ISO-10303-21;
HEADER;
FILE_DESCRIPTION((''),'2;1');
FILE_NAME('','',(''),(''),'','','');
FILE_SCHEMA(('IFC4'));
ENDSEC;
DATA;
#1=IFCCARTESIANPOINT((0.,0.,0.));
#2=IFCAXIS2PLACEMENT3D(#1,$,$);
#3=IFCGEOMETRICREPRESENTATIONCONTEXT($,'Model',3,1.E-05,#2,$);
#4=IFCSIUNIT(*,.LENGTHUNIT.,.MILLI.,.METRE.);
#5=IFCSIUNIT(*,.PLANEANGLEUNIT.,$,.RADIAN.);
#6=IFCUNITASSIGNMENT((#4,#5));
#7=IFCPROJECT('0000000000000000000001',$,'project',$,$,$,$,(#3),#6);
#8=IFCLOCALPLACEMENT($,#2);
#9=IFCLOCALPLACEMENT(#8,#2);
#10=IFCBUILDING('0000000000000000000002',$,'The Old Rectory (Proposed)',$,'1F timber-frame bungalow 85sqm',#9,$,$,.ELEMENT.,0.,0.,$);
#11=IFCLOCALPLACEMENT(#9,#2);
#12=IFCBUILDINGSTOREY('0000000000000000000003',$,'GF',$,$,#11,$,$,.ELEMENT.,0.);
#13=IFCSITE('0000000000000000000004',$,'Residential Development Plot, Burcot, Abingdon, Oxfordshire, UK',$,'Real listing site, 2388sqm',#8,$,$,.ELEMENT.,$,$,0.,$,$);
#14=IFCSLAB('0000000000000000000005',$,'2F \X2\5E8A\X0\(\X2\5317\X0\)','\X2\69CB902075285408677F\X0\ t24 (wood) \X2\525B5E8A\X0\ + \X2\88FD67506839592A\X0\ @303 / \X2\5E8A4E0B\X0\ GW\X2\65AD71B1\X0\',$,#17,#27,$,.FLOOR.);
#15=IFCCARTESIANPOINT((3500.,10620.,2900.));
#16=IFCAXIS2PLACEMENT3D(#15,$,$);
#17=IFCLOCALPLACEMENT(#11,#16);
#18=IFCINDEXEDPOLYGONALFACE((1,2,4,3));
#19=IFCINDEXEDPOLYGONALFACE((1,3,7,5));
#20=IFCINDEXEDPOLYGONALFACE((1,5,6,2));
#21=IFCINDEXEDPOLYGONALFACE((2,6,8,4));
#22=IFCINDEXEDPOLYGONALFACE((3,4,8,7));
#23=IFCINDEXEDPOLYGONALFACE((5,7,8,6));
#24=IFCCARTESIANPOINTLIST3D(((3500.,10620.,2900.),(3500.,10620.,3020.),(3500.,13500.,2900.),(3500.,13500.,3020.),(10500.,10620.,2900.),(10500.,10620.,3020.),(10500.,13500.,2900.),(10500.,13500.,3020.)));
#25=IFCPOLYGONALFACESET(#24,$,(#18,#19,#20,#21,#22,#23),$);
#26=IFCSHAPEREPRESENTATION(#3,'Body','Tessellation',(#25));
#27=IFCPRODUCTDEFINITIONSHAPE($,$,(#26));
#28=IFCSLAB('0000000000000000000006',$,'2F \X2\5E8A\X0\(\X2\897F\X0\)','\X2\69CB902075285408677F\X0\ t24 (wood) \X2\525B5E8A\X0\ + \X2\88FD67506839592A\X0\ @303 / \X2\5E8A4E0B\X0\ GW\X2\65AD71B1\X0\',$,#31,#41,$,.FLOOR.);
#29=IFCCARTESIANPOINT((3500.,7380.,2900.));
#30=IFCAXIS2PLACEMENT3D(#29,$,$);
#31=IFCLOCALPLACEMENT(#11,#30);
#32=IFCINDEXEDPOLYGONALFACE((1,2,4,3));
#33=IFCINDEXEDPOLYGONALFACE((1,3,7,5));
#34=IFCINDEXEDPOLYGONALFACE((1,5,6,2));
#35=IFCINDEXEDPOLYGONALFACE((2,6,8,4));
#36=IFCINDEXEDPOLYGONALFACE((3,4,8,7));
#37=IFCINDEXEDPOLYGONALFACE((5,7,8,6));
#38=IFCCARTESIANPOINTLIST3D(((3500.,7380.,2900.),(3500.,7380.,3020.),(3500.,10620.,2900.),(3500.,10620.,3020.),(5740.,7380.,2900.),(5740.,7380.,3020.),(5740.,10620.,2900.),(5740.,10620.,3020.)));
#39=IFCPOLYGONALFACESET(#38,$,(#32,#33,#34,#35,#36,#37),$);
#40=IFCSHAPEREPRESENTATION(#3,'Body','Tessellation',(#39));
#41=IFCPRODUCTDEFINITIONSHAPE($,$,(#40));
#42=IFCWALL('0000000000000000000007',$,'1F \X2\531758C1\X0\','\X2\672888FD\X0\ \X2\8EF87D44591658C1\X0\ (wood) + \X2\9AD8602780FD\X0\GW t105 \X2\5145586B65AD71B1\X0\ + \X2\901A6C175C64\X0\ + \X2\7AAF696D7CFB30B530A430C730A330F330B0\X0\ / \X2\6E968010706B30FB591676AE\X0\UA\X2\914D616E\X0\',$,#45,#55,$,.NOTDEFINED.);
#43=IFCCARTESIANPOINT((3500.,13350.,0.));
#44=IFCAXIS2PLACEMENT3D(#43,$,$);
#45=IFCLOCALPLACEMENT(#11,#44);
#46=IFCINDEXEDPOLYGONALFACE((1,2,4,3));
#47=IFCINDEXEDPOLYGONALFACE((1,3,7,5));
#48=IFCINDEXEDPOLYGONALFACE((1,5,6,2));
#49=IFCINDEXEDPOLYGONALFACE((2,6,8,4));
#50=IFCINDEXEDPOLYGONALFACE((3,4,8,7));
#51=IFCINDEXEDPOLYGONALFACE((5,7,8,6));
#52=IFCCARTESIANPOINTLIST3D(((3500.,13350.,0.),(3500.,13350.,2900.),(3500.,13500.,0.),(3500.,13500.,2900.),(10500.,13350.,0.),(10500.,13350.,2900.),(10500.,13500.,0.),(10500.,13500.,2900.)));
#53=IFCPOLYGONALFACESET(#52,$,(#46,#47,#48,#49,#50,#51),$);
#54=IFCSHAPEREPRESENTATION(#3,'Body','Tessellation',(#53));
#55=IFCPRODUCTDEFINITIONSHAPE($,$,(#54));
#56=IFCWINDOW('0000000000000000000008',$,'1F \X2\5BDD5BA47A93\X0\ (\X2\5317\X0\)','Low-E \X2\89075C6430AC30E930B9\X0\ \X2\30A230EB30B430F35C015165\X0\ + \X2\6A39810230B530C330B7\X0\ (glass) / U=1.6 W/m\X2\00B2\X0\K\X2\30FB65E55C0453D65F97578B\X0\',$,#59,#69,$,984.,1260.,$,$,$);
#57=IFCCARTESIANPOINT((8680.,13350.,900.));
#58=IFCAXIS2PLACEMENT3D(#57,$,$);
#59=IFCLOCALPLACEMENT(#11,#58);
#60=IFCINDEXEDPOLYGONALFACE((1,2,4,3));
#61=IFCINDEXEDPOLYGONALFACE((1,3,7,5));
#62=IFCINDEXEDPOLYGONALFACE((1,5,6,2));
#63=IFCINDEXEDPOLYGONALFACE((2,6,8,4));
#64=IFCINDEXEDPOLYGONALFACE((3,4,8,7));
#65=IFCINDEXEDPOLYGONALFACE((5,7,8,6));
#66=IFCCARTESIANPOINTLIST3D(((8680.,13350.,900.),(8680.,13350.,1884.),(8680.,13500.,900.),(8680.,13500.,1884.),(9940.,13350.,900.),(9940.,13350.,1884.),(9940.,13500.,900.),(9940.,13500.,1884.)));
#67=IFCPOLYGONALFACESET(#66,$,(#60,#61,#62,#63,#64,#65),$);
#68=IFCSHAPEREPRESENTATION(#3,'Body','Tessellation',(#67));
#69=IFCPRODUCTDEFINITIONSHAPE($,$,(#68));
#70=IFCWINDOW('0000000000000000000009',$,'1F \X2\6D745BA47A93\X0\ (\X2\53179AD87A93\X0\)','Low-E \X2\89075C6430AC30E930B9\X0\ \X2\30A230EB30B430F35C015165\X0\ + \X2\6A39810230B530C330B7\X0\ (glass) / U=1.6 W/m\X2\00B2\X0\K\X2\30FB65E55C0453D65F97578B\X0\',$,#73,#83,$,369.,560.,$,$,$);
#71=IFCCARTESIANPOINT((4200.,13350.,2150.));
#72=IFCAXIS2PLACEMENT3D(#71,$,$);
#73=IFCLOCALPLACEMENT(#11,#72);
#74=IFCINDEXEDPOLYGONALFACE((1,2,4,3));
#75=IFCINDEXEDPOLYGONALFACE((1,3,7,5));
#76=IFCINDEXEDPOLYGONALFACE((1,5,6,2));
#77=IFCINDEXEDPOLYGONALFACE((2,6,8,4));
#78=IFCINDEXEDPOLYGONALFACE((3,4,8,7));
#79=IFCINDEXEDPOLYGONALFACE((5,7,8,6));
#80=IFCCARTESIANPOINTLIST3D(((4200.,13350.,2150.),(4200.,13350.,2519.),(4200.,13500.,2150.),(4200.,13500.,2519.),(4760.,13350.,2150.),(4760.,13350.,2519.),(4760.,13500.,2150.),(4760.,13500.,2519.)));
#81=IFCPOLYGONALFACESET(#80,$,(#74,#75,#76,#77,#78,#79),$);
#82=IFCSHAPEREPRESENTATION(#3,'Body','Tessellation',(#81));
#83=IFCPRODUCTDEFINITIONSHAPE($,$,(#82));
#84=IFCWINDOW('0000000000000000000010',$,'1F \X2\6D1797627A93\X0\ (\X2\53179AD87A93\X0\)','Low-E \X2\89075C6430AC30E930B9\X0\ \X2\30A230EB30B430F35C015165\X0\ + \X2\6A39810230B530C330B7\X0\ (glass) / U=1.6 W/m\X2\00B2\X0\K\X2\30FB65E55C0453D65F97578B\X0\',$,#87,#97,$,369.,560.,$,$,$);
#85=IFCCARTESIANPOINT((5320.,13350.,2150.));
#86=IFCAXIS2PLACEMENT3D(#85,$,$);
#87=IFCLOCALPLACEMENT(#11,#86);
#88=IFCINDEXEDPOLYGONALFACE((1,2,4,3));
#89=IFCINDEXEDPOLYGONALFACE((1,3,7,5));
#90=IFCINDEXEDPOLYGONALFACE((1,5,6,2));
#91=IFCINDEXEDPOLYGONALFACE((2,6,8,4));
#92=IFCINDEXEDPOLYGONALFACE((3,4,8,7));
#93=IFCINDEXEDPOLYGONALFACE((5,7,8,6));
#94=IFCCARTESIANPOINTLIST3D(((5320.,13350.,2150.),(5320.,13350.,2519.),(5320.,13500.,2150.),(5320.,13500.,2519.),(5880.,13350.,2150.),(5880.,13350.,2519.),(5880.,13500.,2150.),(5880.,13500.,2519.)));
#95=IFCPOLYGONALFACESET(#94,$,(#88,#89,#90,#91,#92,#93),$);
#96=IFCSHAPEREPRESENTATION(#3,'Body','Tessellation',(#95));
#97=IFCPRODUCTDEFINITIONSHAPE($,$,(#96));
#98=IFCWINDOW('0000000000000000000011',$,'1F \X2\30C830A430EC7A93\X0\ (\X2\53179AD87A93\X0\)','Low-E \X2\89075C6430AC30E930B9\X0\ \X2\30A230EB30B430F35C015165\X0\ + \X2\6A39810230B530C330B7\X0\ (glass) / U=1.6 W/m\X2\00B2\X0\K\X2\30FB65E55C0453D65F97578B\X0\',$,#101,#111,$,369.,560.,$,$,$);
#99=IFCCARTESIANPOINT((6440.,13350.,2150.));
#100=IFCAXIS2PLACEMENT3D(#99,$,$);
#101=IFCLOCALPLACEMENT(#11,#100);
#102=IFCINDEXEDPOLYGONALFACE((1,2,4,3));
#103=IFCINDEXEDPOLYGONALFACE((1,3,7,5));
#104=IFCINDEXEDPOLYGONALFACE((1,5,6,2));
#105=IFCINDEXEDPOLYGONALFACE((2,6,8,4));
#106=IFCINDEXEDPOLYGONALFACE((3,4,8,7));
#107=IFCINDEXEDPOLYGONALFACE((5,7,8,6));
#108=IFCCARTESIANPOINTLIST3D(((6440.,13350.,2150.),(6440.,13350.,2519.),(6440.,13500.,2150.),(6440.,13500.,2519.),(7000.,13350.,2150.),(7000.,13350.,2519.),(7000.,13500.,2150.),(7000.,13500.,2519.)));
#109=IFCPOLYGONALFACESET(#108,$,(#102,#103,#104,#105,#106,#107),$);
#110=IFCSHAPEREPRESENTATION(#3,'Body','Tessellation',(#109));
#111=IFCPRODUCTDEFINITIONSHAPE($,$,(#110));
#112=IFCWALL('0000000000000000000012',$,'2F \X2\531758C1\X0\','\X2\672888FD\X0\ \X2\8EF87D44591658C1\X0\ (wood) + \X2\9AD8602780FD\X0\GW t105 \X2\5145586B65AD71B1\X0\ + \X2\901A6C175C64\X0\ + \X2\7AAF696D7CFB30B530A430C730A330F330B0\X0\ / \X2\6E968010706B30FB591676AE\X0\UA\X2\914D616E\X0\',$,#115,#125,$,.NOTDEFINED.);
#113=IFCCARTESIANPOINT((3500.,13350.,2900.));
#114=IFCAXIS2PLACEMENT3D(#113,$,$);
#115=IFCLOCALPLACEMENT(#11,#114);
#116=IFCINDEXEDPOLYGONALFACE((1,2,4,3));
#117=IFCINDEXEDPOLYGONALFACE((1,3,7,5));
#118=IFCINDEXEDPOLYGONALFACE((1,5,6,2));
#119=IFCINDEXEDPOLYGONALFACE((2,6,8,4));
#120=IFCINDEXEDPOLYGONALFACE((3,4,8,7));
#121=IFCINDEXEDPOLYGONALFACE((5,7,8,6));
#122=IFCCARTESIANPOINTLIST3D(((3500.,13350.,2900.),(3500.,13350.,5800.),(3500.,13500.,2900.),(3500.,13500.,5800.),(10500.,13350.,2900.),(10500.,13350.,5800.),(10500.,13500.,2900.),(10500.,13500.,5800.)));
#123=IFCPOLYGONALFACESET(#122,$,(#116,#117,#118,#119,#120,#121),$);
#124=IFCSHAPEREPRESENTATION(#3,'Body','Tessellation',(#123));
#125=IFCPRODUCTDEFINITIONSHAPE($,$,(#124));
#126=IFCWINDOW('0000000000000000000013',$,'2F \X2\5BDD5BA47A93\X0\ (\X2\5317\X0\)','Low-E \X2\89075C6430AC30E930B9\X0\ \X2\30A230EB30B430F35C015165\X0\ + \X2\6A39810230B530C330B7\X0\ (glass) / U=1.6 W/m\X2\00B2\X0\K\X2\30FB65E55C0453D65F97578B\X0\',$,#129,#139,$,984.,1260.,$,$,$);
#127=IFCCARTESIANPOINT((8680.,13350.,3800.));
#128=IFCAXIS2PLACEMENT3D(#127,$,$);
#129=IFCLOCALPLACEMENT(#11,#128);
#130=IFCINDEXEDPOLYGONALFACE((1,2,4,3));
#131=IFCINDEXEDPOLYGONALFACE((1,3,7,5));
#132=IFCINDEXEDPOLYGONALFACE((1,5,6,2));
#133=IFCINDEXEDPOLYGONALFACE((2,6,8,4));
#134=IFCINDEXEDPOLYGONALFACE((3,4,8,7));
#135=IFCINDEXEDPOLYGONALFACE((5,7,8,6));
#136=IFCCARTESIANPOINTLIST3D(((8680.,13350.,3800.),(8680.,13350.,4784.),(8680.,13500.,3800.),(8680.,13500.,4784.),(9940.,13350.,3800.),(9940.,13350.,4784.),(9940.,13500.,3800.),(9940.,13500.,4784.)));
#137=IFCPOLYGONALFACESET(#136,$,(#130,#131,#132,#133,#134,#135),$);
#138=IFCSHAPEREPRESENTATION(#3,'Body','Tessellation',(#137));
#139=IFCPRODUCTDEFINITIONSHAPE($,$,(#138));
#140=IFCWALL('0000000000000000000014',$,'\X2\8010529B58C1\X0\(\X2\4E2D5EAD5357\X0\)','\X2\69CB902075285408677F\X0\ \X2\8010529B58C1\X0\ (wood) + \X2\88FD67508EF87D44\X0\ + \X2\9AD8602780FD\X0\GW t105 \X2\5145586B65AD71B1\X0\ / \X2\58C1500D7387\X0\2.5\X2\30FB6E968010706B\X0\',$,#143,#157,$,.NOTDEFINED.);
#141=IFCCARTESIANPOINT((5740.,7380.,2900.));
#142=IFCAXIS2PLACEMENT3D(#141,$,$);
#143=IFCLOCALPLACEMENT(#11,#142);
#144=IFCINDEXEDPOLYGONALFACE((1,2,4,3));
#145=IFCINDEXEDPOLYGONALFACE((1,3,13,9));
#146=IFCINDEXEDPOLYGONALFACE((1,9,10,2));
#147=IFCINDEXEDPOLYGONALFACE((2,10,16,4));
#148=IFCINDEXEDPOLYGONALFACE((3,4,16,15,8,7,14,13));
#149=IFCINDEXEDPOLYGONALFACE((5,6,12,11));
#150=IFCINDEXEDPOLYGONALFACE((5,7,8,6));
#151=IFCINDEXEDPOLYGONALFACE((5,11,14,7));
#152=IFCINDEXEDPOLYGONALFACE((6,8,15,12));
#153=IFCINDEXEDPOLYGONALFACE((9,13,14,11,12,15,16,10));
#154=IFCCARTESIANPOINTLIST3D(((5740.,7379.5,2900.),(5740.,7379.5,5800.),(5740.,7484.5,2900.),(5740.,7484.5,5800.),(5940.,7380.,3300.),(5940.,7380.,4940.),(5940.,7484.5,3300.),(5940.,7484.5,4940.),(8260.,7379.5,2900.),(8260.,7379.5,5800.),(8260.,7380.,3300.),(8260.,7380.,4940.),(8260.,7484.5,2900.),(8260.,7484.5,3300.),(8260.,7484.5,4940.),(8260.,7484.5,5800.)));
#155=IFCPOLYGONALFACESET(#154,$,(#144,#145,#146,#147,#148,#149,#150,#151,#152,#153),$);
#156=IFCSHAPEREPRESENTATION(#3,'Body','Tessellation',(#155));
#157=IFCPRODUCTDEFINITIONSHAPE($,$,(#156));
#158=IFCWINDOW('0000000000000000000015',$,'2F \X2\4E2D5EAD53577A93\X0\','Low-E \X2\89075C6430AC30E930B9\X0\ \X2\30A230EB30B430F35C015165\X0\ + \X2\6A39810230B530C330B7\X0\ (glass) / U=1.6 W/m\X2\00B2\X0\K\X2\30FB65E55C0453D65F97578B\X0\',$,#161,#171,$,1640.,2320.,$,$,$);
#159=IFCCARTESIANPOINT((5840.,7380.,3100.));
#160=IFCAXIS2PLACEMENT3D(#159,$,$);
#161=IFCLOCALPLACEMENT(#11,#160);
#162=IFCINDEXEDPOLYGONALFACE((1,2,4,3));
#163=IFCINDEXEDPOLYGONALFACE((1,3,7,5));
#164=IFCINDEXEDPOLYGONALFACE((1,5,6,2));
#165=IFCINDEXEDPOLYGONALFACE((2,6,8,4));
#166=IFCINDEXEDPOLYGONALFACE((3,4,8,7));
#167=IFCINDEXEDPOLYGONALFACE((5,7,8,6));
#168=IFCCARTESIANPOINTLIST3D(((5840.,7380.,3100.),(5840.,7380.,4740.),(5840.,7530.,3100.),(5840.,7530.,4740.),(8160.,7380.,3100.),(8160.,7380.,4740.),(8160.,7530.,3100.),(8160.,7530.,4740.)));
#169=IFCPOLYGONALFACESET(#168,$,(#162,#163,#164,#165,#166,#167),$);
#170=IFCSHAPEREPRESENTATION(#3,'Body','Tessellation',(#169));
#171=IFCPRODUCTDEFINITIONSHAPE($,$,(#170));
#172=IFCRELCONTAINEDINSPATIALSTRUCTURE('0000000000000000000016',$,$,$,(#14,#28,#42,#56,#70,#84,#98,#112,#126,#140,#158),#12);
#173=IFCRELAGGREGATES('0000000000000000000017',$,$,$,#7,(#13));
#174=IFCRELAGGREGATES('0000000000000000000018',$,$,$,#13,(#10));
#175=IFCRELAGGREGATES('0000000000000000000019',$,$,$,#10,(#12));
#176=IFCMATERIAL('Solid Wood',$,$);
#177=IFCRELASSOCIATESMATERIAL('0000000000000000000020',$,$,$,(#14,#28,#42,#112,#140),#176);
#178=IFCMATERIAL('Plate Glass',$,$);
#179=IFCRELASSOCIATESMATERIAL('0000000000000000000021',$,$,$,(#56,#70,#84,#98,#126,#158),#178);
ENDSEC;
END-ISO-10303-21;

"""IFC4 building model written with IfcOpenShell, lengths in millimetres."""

from ifc_helpers import new_model, si_unit, frame, frame_2d, origin, place, context, project, spatial, rectangle, extrude, material, element, fill, save


model = new_model("IFC4")

# Units and contexts
model_context = context("Model", 3, precision=1e-05, world=origin())
ifc_project = project(units=[si_unit("LENGTHUNIT", "METRE", prefix="MILLI"), si_unit("PLANEANGLEUNIT", "RADIAN")], contexts=[model_context])

# Site, building, storey
site_placement = place(None, origin())
site = spatial("IfcSite", under=ifc_project, at=site_placement, Name="Residential Development Plot, Burcot, Abingdon, Oxfordshire, UK", ObjectType="Real listing site, 2388sqm", CompositionType="ELEMENT", RefElevation=0.0)
building_placement = place(site_placement, origin())
building = spatial("IfcBuilding", under=site, at=building_placement, Name="The Old Rectory (Proposed)", ObjectType="1F timber-frame bungalow 85sqm", CompositionType="ELEMENT", ElevationOfRefHeight=0.0, ElevationOfTerrain=0.0)
storey_placement = place(building_placement, origin())
storey = spatial("IfcBuildingStorey", under=building, at=storey_placement, Name="GF", CompositionType="ELEMENT", Elevation=0.0)

# Slabs
ifc_material_1 = material(Name="Solid Wood")
slab_1_placement = place(storey_placement, frame((3500.0, 10620.0, 2900.0)))
element("IfcSlab", 1, at=slab_1_placement, inside=storey, material=ifc_material_1, Name="2F 床(北)", Description="構造用合板 t24 (wood) 剛床 + 製材根太 @303 / 床下 GW断熱", PredefinedType="FLOOR", context=model_context, shape_type="SweptSolid", body=[
    extrude(rectangle(XDim=7000.0, YDim=2880.0, at=frame_2d((3500.0, 1440.0))), frame((3500.0, 10620.0, 2900.0)), (0.0, 0.0, 1.0), 120.0),
])
slab_2_placement = place(storey_placement, frame((3500.0, 7380.0, 2900.0)))
element("IfcSlab", 2, at=slab_2_placement, inside=storey, material=ifc_material_1, Name="2F 床(西)", Description="構造用合板 t24 (wood) 剛床 + 製材根太 @303 / 床下 GW断熱", PredefinedType="FLOOR", context=model_context, shape_type="SweptSolid", body=[
    extrude(rectangle(XDim=2240.0, YDim=3240.0, at=frame_2d((1120.0, 1620.0))), frame((3500.0, 7380.0, 2900.0)), (0.0, 0.0, 1.0), 120.0),
])

# Wall, openings, windows
wall_1_placement = place(storey_placement, frame((3500.0, 13350.0, 0.0)))
wall_1 = element("IfcWall", 3, at=wall_1_placement, inside=storey, material=ifc_material_1, Name="1F 北壁", Description="木製 軸組外壁 (wood) + 高性能GW t105 充填断熱 + 通気層 + 窯業系サイディング / 準耐火・外皮UA配慮", PredefinedType="NOTDEFINED", context=model_context, shape_type="SweptSolid", body=[
    extrude(rectangle(XDim=7000.0, YDim=150.0, at=frame_2d((3500.0, 75.0))), frame((3500.0, 13350.0, 0.0)), (0.0, 0.0, 1.0), 2900.0),
])
opening_1_placement = place(storey_placement, frame((8680.0, 13350.0, 900.0)))
opening_1 = element("IfcOpeningElement", 4, at=opening_1_placement, cuts=wall_1, PredefinedType="NOTDEFINED", context=model_context, shape_type="SweptSolid", body=[
    extrude(rectangle(XDim=1260.0, YDim=150.0, at=frame_2d((630.0, 75.0))), frame((8680.0, 13350.0, 900.0)), (0.0, 0.0, 1.0), 984.0),
])
opening_2_placement = place(storey_placement, frame((4200.0, 13350.0, 2150.0)))
opening_2 = element("IfcOpeningElement", 5, at=opening_2_placement, cuts=wall_1, PredefinedType="NOTDEFINED", context=model_context, shape_type="SweptSolid", body=[
    extrude(rectangle(XDim=560.0, YDim=150.0, at=frame_2d((280.0, 75.0))), frame((4200.0, 13350.0, 2150.0)), (0.0, 0.0, 1.0), 369.0),
])
opening_3_placement = place(storey_placement, frame((5320.0, 13350.0, 2150.0)))
opening_3 = element("IfcOpeningElement", 6, at=opening_3_placement, cuts=wall_1, PredefinedType="NOTDEFINED", context=model_context, shape_type="SweptSolid", body=[
    extrude(rectangle(XDim=560.0, YDim=150.0, at=frame_2d((280.0, 75.0))), frame((5320.0, 13350.0, 2150.0)), (0.0, 0.0, 1.0), 369.0),
])
opening_4_placement = place(storey_placement, frame((6440.0, 13350.0, 2150.0)))
opening_4 = element("IfcOpeningElement", 7, at=opening_4_placement, cuts=wall_1, PredefinedType="NOTDEFINED", context=model_context, shape_type="SweptSolid", body=[
    extrude(rectangle(XDim=560.0, YDim=150.0, at=frame_2d((280.0, 75.0))), frame((6440.0, 13350.0, 2150.0)), (0.0, 0.0, 1.0), 369.0),
])
ifc_material_2 = material(Name="Plate Glass")
window_1_placement = place(storey_placement, frame((8680.0, 13350.0, 900.0)))
window_1 = element("IfcWindow", 8, at=window_1_placement, inside=storey, material=ifc_material_2, Name="1F 寝室窓 (北)", Description="Low-E 複層ガラス アルゴン封入 + 樹脂サッシ (glass) / U=1.6 W/m²K・日射取得型", OverallHeight=984.0, OverallWidth=1260.0, context=model_context, shape_type="SweptSolid", body=[
    extrude(rectangle(XDim=1260.0, YDim=150.0, at=frame_2d((630.0, 75.0))), frame((8680.0, 13350.0, 900.0)), (0.0, 0.0, 1.0), 984.0),
])
fill(opening_1, window_1)
window_2_placement = place(storey_placement, frame((4200.0, 13350.0, 2150.0)))
window_2 = element("IfcWindow", 9, at=window_2_placement, inside=storey, material=ifc_material_2, Name="1F 浴室窓 (北高窓)", Description="Low-E 複層ガラス アルゴン封入 + 樹脂サッシ (glass) / U=1.6 W/m²K・日射取得型", OverallHeight=369.0, OverallWidth=560.0, context=model_context, shape_type="SweptSolid", body=[
    extrude(rectangle(XDim=560.0, YDim=150.0, at=frame_2d((280.0, 75.0))), frame((4200.0, 13350.0, 2150.0)), (0.0, 0.0, 1.0), 369.0),
])
fill(opening_2, window_2)
window_3_placement = place(storey_placement, frame((5320.0, 13350.0, 2150.0)))
window_3 = element("IfcWindow", 10, at=window_3_placement, inside=storey, material=ifc_material_2, Name="1F 洗面窓 (北高窓)", Description="Low-E 複層ガラス アルゴン封入 + 樹脂サッシ (glass) / U=1.6 W/m²K・日射取得型", OverallHeight=369.0, OverallWidth=560.0, context=model_context, shape_type="SweptSolid", body=[
    extrude(rectangle(XDim=560.0, YDim=150.0, at=frame_2d((280.0, 75.0))), frame((5320.0, 13350.0, 2150.0)), (0.0, 0.0, 1.0), 369.0),
])
fill(opening_3, window_3)
window_4_placement = place(storey_placement, frame((6440.0, 13350.0, 2150.0)))
window_4 = element("IfcWindow", 11, at=window_4_placement, inside=storey, material=ifc_material_2, Name="1F トイレ窓 (北高窓)", Description="Low-E 複層ガラス アルゴン封入 + 樹脂サッシ (glass) / U=1.6 W/m²K・日射取得型", OverallHeight=369.0, OverallWidth=560.0, context=model_context, shape_type="SweptSolid", body=[
    extrude(rectangle(XDim=560.0, YDim=150.0, at=frame_2d((280.0, 75.0))), frame((6440.0, 13350.0, 2150.0)), (0.0, 0.0, 1.0), 369.0),
])
fill(opening_4, window_4)

# Walls, openings, windows
wall_2_placement = place(storey_placement, frame((3500.0, 13350.0, 2900.0)))
wall_2 = element("IfcWall", 12, at=wall_2_placement, inside=storey, material=ifc_material_1, Name="2F 北壁", Description="木製 軸組外壁 (wood) + 高性能GW t105 充填断熱 + 通気層 + 窯業系サイディング / 準耐火・外皮UA配慮", PredefinedType="NOTDEFINED", context=model_context, shape_type="SweptSolid", body=[
    extrude(rectangle(XDim=7000.0, YDim=150.0, at=frame_2d((3500.0, 75.0))), frame((3500.0, 13350.0, 2900.0)), (0.0, 0.0, 1.0), 2900.0),
])
opening_5_placement = place(storey_placement, frame((8680.0, 13350.0, 3800.0)))
opening_5 = element("IfcOpeningElement", 13, at=opening_5_placement, cuts=wall_2, PredefinedType="NOTDEFINED", context=model_context, shape_type="SweptSolid", body=[
    extrude(rectangle(XDim=1260.0, YDim=150.0, at=frame_2d((630.0, 75.0))), frame((8680.0, 13350.0, 3800.0)), (0.0, 0.0, 1.0), 984.0),
])
window_5_placement = place(storey_placement, frame((8680.0, 13350.0, 3800.0)))
window_5 = element("IfcWindow", 14, at=window_5_placement, inside=storey, material=ifc_material_2, Name="2F 寝室窓 (北)", Description="Low-E 複層ガラス アルゴン封入 + 樹脂サッシ (glass) / U=1.6 W/m²K・日射取得型", OverallHeight=984.0, OverallWidth=1260.0, context=model_context, shape_type="SweptSolid", body=[
    extrude(rectangle(XDim=1260.0, YDim=150.0, at=frame_2d((630.0, 75.0))), frame((8680.0, 13350.0, 3800.0)), (0.0, 0.0, 1.0), 984.0),
])
fill(opening_5, window_5)
wall_3_placement = place(storey_placement, frame((5740.0, 7380.0, 2900.0)))
wall_3 = element("IfcWall", 15, at=wall_3_placement, inside=storey, material=ifc_material_1, Name="耐力壁(中庭南)", Description="構造用合板 耐力壁 (wood) + 製材軸組 + 高性能GW t105 充填断熱 / 壁倍率2.5・準耐火", PredefinedType="NOTDEFINED", context=model_context, shape_type="SweptSolid", body=[
    extrude(rectangle(XDim=2520.0, YDim=105.0, at=frame_2d((1260.0, 52.0))), frame((5740.0, 7380.0, 2900.0)), (0.0, 0.0, 1.0), 2900.0),
])
opening_6_placement = place(storey_placement, frame((5840.0, 7380.0, 3100.0)))
opening_6 = element("IfcOpeningElement", 16, at=opening_6_placement, cuts=wall_3, PredefinedType="NOTDEFINED", context=model_context, shape_type="SweptSolid", body=[
    extrude(rectangle(XDim=2320.0, YDim=150.0, at=frame_2d((1160.0, 75.0))), frame((5840.0, 7380.0, 3100.0)), (0.0, 0.0, 1.0), 1640.0),
])
window_6_placement = place(storey_placement, frame((5840.0, 7380.0, 3100.0)))
window_6 = element("IfcWindow", 17, at=window_6_placement, inside=storey, material=ifc_material_2, Name="2F 中庭南窓", Description="Low-E 複層ガラス アルゴン封入 + 樹脂サッシ (glass) / U=1.6 W/m²K・日射取得型", OverallHeight=1640.0, OverallWidth=2320.0, context=model_context, shape_type="SweptSolid", body=[
    extrude(rectangle(XDim=2320.0, YDim=150.0, at=frame_2d((1160.0, 75.0))), frame((5840.0, 7380.0, 3100.0)), (0.0, 0.0, 1.0), 1640.0),
])
fill(opening_6, window_6)

save(model, "model.ifc")
